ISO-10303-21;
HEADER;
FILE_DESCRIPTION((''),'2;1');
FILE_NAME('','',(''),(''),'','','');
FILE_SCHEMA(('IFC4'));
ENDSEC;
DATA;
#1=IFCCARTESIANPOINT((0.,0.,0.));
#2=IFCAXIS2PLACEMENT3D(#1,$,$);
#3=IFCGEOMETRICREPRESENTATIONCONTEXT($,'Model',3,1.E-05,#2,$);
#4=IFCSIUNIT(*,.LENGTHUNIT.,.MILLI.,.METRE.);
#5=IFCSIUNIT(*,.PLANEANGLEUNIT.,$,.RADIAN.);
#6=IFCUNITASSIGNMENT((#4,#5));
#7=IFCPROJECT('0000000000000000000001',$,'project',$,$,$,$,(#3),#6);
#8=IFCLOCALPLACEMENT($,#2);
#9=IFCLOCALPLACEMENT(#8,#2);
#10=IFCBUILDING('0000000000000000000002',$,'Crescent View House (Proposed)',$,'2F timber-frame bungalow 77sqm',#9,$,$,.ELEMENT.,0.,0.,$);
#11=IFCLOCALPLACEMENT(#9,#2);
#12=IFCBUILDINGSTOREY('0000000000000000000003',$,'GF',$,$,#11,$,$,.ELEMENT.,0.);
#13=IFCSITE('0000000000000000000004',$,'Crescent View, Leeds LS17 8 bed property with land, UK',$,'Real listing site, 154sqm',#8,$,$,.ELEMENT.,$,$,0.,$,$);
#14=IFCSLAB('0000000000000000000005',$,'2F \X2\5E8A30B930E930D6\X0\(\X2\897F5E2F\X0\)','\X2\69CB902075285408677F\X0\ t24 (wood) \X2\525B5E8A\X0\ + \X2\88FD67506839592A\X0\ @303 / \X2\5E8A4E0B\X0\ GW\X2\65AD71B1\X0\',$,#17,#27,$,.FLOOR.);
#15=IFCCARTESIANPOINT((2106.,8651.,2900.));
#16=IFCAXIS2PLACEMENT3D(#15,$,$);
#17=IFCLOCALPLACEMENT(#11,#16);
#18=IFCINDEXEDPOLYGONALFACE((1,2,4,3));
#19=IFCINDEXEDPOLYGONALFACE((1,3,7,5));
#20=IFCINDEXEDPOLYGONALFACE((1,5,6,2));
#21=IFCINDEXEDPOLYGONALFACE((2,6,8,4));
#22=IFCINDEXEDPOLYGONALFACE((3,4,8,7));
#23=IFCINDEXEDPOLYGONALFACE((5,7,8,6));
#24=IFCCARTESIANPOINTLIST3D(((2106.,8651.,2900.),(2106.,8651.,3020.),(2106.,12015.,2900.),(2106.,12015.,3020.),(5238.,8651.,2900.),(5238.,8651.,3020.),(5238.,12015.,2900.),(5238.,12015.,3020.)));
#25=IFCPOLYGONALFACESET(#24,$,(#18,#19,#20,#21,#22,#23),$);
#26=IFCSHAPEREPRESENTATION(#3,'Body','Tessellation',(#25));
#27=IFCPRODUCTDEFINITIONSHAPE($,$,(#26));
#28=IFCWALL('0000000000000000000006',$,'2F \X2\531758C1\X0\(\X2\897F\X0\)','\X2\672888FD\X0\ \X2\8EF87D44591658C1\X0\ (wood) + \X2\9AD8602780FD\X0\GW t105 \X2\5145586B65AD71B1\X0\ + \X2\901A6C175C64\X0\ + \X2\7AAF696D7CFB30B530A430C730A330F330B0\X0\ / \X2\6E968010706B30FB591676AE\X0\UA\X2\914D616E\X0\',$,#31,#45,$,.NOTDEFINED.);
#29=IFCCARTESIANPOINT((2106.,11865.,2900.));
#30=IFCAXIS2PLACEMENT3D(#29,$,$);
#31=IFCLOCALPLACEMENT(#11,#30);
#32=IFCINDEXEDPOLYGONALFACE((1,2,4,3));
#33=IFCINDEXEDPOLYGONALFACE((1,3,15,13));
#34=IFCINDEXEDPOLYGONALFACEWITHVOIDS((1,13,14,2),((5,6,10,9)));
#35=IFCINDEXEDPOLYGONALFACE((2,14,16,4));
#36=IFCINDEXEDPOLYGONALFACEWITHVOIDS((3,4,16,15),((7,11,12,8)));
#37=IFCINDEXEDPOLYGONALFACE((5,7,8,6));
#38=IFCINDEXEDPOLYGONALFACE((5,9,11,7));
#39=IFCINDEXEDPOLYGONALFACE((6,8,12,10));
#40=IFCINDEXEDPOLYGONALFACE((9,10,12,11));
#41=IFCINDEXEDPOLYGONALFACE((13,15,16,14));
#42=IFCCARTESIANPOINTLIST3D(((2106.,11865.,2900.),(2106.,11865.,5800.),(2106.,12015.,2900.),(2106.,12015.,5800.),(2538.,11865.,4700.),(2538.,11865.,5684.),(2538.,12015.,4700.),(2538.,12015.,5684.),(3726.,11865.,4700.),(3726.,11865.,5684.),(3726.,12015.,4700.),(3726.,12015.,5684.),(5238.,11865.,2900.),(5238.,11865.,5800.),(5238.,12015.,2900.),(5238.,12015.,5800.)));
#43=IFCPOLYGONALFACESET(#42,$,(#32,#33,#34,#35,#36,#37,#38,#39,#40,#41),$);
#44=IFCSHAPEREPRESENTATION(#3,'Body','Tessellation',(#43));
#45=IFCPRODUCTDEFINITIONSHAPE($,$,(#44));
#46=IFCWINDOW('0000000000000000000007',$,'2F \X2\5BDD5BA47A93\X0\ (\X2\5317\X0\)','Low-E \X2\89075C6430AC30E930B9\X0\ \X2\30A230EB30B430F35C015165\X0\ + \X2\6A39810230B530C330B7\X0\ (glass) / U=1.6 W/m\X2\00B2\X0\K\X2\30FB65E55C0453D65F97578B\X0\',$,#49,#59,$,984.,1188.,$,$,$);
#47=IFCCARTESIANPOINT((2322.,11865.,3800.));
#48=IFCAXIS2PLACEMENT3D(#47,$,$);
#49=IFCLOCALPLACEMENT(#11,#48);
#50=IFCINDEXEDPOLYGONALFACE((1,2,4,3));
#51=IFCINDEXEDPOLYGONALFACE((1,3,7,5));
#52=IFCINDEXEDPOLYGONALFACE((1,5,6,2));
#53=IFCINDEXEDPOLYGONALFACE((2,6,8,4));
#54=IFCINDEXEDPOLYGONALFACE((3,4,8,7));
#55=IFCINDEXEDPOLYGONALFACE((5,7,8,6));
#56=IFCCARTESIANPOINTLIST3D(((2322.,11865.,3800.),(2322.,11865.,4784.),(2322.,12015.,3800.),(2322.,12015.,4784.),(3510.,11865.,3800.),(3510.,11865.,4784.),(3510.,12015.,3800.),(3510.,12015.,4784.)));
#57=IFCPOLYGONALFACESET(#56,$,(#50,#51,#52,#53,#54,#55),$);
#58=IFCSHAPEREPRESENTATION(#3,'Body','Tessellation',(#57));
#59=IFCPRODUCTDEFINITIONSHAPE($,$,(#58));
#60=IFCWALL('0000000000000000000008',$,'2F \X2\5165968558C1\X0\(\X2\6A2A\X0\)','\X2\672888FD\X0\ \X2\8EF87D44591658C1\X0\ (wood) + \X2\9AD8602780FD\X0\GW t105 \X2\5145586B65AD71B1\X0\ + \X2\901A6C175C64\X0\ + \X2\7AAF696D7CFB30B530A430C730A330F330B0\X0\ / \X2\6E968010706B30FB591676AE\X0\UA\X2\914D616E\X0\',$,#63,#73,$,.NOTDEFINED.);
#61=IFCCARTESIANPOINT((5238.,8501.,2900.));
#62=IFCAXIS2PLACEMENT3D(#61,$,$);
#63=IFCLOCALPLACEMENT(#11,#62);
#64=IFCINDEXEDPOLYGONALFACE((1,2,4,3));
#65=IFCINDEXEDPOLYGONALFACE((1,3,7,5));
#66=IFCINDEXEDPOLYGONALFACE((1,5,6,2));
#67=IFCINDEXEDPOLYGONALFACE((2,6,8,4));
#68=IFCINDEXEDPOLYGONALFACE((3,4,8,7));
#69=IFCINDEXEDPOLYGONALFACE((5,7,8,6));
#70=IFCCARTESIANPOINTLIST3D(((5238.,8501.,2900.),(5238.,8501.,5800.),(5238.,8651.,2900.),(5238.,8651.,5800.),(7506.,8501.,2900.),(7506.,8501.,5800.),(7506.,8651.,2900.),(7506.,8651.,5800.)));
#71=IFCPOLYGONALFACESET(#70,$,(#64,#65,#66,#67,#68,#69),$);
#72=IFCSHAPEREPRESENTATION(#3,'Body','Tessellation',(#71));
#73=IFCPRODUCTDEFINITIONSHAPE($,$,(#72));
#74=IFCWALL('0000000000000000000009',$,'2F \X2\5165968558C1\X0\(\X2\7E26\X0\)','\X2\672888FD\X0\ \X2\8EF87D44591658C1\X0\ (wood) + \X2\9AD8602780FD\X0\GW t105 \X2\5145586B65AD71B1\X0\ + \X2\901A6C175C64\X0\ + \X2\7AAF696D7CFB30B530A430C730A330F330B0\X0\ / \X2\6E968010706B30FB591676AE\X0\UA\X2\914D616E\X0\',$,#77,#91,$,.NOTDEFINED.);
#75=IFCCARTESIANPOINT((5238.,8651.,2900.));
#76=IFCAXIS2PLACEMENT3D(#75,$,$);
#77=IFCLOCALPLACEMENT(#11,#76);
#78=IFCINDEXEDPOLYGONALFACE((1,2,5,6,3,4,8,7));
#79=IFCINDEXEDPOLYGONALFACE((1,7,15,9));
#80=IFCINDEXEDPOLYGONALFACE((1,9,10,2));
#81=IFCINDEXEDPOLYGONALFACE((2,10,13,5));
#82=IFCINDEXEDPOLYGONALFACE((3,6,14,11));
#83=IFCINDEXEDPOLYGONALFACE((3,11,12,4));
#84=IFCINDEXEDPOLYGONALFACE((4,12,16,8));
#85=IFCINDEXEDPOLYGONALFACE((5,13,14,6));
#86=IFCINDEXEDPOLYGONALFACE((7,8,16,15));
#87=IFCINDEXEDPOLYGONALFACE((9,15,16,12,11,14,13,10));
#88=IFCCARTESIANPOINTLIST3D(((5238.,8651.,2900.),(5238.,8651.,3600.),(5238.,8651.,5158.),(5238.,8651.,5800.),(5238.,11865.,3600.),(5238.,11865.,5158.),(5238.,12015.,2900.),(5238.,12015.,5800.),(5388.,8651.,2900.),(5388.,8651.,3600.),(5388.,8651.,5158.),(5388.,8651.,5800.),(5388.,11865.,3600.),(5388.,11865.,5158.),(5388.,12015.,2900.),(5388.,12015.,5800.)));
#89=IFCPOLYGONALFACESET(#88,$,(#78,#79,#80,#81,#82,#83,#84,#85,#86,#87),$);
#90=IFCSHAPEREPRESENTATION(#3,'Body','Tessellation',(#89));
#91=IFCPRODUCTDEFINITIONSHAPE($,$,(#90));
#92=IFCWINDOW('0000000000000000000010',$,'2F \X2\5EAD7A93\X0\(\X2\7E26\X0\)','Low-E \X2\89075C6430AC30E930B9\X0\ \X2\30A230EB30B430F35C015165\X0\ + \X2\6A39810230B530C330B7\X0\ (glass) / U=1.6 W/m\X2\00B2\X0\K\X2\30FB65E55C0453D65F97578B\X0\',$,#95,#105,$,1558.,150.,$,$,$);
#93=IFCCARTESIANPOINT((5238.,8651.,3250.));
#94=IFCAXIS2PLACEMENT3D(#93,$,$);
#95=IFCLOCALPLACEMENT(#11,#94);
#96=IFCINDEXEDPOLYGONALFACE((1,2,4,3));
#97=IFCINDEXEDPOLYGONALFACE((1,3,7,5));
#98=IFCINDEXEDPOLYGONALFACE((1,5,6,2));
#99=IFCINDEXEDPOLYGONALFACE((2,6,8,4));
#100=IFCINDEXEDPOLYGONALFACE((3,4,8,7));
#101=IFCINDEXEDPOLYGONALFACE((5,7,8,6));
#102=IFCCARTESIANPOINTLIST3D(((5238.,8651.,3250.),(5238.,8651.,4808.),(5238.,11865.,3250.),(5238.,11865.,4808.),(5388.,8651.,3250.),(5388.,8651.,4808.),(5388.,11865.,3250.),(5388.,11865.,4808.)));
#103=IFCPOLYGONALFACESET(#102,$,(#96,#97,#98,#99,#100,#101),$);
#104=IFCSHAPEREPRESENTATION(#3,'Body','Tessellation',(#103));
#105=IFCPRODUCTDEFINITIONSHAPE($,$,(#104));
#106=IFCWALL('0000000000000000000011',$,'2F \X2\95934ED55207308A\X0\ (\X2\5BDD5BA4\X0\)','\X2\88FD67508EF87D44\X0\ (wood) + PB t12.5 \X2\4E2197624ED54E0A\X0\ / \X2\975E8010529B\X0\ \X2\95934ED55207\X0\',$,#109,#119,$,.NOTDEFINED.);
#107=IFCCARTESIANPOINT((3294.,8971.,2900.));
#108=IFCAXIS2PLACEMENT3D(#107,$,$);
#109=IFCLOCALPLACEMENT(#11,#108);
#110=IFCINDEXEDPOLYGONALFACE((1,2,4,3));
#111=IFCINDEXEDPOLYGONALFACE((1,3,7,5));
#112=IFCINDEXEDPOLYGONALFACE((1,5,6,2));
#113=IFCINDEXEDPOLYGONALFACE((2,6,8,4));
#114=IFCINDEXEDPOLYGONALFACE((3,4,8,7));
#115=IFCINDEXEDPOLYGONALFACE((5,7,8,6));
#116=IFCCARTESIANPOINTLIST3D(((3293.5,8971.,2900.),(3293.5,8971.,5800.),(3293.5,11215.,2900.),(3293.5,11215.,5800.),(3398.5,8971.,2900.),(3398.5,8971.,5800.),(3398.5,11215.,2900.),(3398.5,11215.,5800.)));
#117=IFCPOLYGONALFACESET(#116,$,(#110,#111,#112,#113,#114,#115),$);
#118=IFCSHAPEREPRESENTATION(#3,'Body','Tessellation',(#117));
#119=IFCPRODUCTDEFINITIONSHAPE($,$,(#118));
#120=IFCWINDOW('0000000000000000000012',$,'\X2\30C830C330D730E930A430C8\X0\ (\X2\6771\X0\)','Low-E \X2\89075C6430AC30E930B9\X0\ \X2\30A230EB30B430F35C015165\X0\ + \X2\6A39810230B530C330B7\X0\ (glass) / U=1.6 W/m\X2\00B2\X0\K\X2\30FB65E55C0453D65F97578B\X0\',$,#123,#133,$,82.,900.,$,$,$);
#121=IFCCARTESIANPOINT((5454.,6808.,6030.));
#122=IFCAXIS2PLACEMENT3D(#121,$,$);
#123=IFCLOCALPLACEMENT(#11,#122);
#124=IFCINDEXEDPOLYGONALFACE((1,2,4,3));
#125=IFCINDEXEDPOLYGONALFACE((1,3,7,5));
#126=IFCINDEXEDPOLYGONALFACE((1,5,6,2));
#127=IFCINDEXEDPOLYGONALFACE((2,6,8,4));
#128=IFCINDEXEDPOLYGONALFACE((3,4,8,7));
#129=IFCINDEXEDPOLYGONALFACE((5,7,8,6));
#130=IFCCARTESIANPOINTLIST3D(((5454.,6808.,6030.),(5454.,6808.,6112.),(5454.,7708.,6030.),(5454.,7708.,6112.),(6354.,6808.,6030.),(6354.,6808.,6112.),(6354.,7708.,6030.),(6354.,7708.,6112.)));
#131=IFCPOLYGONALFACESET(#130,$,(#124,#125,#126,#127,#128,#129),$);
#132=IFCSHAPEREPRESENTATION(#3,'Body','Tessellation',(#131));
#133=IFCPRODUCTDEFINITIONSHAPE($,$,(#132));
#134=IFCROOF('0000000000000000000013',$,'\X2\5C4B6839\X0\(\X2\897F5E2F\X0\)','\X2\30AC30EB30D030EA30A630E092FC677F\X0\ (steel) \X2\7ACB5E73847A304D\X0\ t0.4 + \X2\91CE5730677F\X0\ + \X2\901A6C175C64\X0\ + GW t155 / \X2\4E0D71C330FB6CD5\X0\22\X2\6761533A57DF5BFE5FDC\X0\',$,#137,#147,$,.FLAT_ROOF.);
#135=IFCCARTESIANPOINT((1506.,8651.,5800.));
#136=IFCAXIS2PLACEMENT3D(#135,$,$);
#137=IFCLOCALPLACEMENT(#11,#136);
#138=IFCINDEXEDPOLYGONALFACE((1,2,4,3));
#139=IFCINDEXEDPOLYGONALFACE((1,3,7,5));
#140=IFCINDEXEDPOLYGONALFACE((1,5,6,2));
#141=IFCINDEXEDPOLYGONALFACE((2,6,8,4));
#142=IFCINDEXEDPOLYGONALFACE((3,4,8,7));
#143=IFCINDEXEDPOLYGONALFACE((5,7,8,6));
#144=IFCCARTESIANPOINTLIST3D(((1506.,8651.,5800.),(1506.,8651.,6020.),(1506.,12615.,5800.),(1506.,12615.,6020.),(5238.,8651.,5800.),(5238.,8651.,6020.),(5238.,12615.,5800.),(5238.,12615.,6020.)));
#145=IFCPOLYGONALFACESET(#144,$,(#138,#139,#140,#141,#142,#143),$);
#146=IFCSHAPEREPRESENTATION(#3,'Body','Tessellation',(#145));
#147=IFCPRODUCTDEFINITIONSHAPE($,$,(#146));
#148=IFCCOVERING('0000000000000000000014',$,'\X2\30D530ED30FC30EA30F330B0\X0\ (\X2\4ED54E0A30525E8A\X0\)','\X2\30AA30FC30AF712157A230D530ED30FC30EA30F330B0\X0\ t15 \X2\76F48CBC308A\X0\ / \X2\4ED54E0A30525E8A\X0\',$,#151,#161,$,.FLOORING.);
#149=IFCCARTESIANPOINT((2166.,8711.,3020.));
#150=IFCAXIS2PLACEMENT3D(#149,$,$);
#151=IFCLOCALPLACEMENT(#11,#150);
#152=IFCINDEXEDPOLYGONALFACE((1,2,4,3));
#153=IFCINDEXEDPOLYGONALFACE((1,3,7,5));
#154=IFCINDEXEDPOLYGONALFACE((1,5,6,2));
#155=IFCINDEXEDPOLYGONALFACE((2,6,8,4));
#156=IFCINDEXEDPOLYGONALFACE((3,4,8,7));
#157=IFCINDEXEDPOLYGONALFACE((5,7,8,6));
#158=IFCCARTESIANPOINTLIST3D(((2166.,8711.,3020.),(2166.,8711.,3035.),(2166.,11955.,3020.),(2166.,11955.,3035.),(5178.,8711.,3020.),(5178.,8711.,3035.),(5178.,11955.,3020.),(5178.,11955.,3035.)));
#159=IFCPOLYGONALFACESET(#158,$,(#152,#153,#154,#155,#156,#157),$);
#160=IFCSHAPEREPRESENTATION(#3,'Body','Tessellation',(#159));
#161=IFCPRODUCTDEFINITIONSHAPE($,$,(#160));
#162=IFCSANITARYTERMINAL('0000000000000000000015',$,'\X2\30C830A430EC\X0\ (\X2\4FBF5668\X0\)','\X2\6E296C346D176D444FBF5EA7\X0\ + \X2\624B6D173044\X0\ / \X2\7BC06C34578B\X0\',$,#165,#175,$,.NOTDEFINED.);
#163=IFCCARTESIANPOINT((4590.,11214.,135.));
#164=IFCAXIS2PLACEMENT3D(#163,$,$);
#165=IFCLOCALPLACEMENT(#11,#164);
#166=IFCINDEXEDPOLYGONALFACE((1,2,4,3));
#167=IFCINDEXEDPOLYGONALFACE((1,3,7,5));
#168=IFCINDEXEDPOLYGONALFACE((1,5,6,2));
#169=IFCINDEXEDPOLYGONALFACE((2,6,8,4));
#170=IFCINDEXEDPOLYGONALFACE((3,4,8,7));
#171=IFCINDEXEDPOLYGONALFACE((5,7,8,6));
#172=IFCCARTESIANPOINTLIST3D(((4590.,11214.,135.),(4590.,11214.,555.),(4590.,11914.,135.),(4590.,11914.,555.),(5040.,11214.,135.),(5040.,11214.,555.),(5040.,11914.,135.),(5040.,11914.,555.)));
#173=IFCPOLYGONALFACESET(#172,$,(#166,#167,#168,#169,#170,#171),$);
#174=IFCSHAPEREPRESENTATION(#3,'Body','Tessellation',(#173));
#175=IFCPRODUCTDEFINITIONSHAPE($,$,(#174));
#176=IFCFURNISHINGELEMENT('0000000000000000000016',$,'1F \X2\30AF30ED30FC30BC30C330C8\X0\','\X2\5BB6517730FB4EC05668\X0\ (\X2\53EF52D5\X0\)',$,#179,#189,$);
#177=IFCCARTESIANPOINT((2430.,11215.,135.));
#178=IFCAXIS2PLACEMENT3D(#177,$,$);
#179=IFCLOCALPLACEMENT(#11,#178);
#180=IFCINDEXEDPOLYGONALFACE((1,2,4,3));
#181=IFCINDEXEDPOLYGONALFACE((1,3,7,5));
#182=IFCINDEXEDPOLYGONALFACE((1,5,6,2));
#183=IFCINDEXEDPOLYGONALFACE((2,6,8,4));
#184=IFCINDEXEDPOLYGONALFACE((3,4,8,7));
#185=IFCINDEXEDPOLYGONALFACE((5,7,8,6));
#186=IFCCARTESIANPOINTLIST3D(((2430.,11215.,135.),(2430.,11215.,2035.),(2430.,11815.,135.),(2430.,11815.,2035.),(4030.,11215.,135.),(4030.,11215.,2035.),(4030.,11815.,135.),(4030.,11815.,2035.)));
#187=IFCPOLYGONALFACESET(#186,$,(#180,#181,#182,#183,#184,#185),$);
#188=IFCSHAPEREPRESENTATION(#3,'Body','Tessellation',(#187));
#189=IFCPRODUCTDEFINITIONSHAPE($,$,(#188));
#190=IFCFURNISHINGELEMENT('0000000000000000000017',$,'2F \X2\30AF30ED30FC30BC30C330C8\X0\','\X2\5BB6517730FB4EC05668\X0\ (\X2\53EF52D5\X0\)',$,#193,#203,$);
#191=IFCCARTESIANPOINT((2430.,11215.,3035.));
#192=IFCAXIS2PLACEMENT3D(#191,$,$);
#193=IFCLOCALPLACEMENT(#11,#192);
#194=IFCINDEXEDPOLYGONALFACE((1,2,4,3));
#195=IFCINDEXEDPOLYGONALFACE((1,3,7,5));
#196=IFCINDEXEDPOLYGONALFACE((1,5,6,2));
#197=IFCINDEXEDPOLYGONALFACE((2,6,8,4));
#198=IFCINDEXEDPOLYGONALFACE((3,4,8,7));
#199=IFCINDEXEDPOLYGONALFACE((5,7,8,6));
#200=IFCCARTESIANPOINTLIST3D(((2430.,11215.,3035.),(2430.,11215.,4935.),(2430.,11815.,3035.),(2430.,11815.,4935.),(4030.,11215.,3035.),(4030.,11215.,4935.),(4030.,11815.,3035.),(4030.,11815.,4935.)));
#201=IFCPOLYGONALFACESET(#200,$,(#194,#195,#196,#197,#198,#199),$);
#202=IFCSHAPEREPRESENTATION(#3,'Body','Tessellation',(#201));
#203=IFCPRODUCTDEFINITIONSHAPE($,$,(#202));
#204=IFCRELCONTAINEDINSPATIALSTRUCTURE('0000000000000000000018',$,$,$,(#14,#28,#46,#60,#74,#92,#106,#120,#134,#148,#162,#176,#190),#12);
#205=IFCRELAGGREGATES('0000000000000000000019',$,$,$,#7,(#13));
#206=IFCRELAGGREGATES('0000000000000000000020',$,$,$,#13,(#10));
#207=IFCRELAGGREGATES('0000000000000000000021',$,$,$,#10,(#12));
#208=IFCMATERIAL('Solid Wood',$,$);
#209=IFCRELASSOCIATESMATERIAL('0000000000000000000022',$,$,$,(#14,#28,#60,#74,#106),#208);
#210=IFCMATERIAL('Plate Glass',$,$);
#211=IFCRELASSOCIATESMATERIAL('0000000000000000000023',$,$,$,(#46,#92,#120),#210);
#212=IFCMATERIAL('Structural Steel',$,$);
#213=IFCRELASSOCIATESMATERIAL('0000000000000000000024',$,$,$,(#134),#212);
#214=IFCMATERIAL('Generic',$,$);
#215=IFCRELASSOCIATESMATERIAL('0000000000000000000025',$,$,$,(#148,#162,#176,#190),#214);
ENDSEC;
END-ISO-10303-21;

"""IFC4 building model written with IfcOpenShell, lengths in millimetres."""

from ifc_helpers import new_model, si_unit, frame, frame_2d, origin, place, context, project, spatial, rectangle, extrude, material, element, fill, save


model = new_model("IFC4")

# Units and contexts
model_context = context("Model", 3, precision=1e-05, world=origin())
ifc_project = project(units=[si_unit("LENGTHUNIT", "METRE", prefix="MILLI"), si_unit("PLANEANGLEUNIT", "RADIAN")], contexts=[model_context])

# Site, building, storey
site_placement = place(None, origin())
site = spatial("IfcSite", under=ifc_project, at=site_placement, Name="Crescent View, Leeds LS17 8 bed property with land, UK", ObjectType="Real listing site, 154sqm", CompositionType="ELEMENT", RefElevation=0.0)
building_placement = place(site_placement, origin())
building = spatial("IfcBuilding", under=site, at=building_placement, Name="Crescent View House (Proposed)", ObjectType="2F timber-frame bungalow 77sqm", CompositionType="ELEMENT", ElevationOfRefHeight=0.0, ElevationOfTerrain=0.0)
storey_placement = place(building_placement, origin())
storey = spatial("IfcBuildingStorey", under=building, at=storey_placement, Name="GF", CompositionType="ELEMENT", Elevation=0.0)

# Slab
ifc_material_1 = material(Name="Solid Wood")
slab_placement = place(storey_placement, frame((2106.0, 8651.0, 2900.0)))
element("IfcSlab", 1, at=slab_placement, inside=storey, material=ifc_material_1, Name="2F 床スラブ(西帯)", Description="構造用合板 t24 (wood) 剛床 + 製材根太 @303 / 床下 GW断熱", PredefinedType="FLOOR", context=model_context, shape_type="SweptSolid", body=[
    extrude(rectangle(XDim=3132.0, YDim=3364.0, at=frame_2d((1566.0, 1682.0))), frame((2106.0, 8651.0, 2900.0)), (0.0, 0.0, 1.0), 120.0),
])

# Wall, opening, window
wall_1_placement = place(storey_placement, frame((2106.0, 11865.0, 2900.0)))
wall_1 = element("IfcWall", 2, at=wall_1_placement, inside=storey, material=ifc_material_1, Name="2F 北壁(西)", Description="木製 軸組外壁 (wood) + 高性能GW t105 充填断熱 + 通気層 + 窯業系サイディング / 準耐火・外皮UA配慮", PredefinedType="NOTDEFINED", context=model_context, shape_type="SweptSolid", body=[
    extrude(rectangle(XDim=3132.0, YDim=150.0, at=frame_2d((1566.0, 75.0))), frame((2106.0, 11865.0, 2900.0)), (0.0, 0.0, 1.0), 2900.0),
])
opening_1_placement = place(storey_placement, frame((2322.0, 11865.0, 3800.0)))
opening_1 = element("IfcOpeningElement", 3, at=opening_1_placement, cuts=wall_1, PredefinedType="NOTDEFINED", context=model_context, shape_type="SweptSolid", body=[
    extrude(rectangle(XDim=1188.0, YDim=150.0, at=frame_2d((594.0, 75.0))), frame((2322.0, 11865.0, 3800.0)), (0.0, 0.0, 1.0), 984.0),
])
ifc_material_2 = material(Name="Plate Glass")
window_1_placement = place(storey_placement, frame((2322.0, 11865.0, 3800.0)))
window_1 = element("IfcWindow", 4, at=window_1_placement, inside=storey, material=ifc_material_2, Name="2F 寝室窓 (北)", Description="Low-E 複層ガラス アルゴン封入 + 樹脂サッシ (glass) / U=1.6 W/m²K・日射取得型", OverallHeight=984.0, OverallWidth=1188.0, context=model_context, shape_type="SweptSolid", body=[
    extrude(rectangle(XDim=1188.0, YDim=150.0, at=frame_2d((594.0, 75.0))), frame((2322.0, 11865.0, 3800.0)), (0.0, 0.0, 1.0), 984.0),
])
fill(opening_1, window_1)

# Wall
wall_2_placement = place(storey_placement, frame((5238.0, 8501.0, 2900.0)))
element("IfcWall", 5, at=wall_2_placement, inside=storey, material=ifc_material_1, Name="2F 入隅壁(横)", Description="木製 軸組外壁 (wood) + 高性能GW t105 充填断熱 + 通気層 + 窯業系サイディング / 準耐火・外皮UA配慮", PredefinedType="NOTDEFINED", context=model_context, shape_type="SweptSolid", body=[
    extrude(rectangle(XDim=2268.0, YDim=150.0, at=frame_2d((1134.0, 75.0))), frame((5238.0, 8501.0, 2900.0)), (0.0, 0.0, 1.0), 2900.0),
])

# Wall, opening, window
wall_3_placement = place(storey_placement, frame((5238.0, 8651.0, 2900.0)))
wall_3 = element("IfcWall", 6, at=wall_3_placement, inside=storey, material=ifc_material_1, Name="2F 入隅壁(縦)", Description="木製 軸組外壁 (wood) + 高性能GW t105 充填断熱 + 通気層 + 窯業系サイディング / 準耐火・外皮UA配慮", PredefinedType="NOTDEFINED", context=model_context, shape_type="SweptSolid", body=[
    extrude(rectangle(XDim=150.0, YDim=3364.0, at=frame_2d((75.0, 1682.0))), frame((5238.0, 8651.0, 2900.0)), (0.0, 0.0, 1.0), 2900.0),
])
opening_2_placement = place(storey_placement, frame((5238.0, 8651.0, 3250.0)))
opening_2 = element("IfcOpeningElement", 7, at=opening_2_placement, cuts=wall_3, PredefinedType="NOTDEFINED", context=model_context, shape_type="SweptSolid", body=[
    extrude(rectangle(XDim=150.0, YDim=3214.0, at=frame_2d((75.0, 1607.0))), frame((5238.0, 8651.0, 3250.0)), (0.0, 0.0, 1.0), 1558.0),
])
window_2_placement = place(storey_placement, frame((5238.0, 8651.0, 3250.0)))
window_2 = element("IfcWindow", 8, at=window_2_placement, inside=storey, material=ifc_material_2, Name="2F 庭窓(縦)", Description="Low-E 複層ガラス アルゴン封入 + 樹脂サッシ (glass) / U=1.6 W/m²K・日射取得型", OverallHeight=1558.0, OverallWidth=150.0, context=model_context, shape_type="SweptSolid", body=[
    extrude(rectangle(XDim=150.0, YDim=3214.0, at=frame_2d((75.0, 1607.0))), frame((5238.0, 8651.0, 3250.0)), (0.0, 0.0, 1.0), 1558.0),
])
fill(opening_2, window_2)

# Wall
wall_4_placement = place(storey_placement, frame((3294.0, 8971.0, 2900.0)))
element("IfcWall", 9, at=wall_4_placement, inside=storey, material=ifc_material_1, Name="2F 間仕切り (寝室)", Description="製材軸組 (wood) + PB t12.5 両面仕上 / 非耐力 間仕切", PredefinedType="NOTDEFINED", context=model_context, shape_type="SweptSolid", body=[
    extrude(rectangle(XDim=105.0, YDim=2244.0, at=frame_2d((52.0, 1122.0))), frame((3294.0, 8971.0, 2900.0)), (0.0, 0.0, 1.0), 2900.0),
])

# Window
window_3_placement = place(storey_placement, frame((5454.0, 6808.0, 6030.0)))
element("IfcWindow", 10, at=window_3_placement, inside=storey, material=ifc_material_2, Name="トップライト (東)", Description="Low-E 複層ガラス アルゴン封入 + 樹脂サッシ (glass) / U=1.6 W/m²K・日射取得型", OverallHeight=82.0, OverallWidth=900.0, context=model_context, shape_type="SweptSolid", body=[
    extrude(rectangle(XDim=900.0, YDim=900.0, at=frame_2d((450.0, 450.0))), frame((5454.0, 6808.0, 6030.0)), (0.0, 0.0, 1.0), 82.0),
])

# Roof
ifc_material_3 = material(Name="Structural Steel")
for number, where, name in (
    (11, (1506.0, 8651.0, 5800.0), "屋根(西帯)"),
):
    element("IfcRoof", number, at=place(storey_placement, frame(where)), inside=storey, material=ifc_material_3, Name=name, Description="ガルバリウム鋼板 (steel) 立平葺き t0.4 + 野地板 + 通気層 + GW t155 / 不燃・法22条区域対応", PredefinedType="FLAT_ROOF", context=model_context, shape_type="SweptSolid", body=[
        extrude(rectangle(XDim=3732.0, YDim=3964.0, at=frame_2d((1866.0, 1982.0))), frame((1506.0, 8651.0, 5800.0)), (0.0, 0.0, 1.0), 220.0),
    ])

# Covering
ifc_material_4 = material(Name="Generic")
covering_placement = place(storey_placement, frame((2166.0, 8711.0, 3020.0)))
element("IfcCovering", 12, at=covering_placement, inside=storey, material=ifc_material_4, Name="フローリング (仕上げ床)", Description="オーク無垢フローリング t15 直貼り / 仕上げ床", PredefinedType="FLOORING", context=model_context, shape_type="SweptSolid", body=[
    extrude(rectangle(XDim=3012.0, YDim=3244.0, at=frame_2d((1506.0, 1622.0))), frame((2166.0, 8711.0, 3020.0)), (0.0, 0.0, 1.0), 15.0),
])

# Sanitary terminal
sanitary_terminal_placement = place(storey_placement, frame((4590.0, 11214.0, 135.0)))
element("IfcSanitaryTerminal", 13, at=sanitary_terminal_placement, inside=storey, material=ifc_material_4, Name="トイレ (便器)", Description="温水洗浄便座 + 手洗い / 節水型", PredefinedType="NOTDEFINED", context=model_context, shape_type="SweptSolid", body=[
    extrude(rectangle(XDim=450.0, YDim=700.0, at=frame_2d((225.0, 350.0))), frame((4590.0, 11214.0, 135.0)), (0.0, 0.0, 1.0), 420.0),
])

# Furnishing elements
furnishing_1_placement = place(storey_placement, frame((2430.0, 11215.0, 135.0)))
element("IfcFurnishingElement", 14, at=furnishing_1_placement, inside=storey, material=ifc_material_4, Name="1F クローゼット", Description="家具・什器 (可動)", context=model_context, shape_type="SweptSolid", body=[
    extrude(rectangle(XDim=1600.0, YDim=600.0, at=frame_2d((800.0, 300.0))), frame((2430.0, 11215.0, 135.0)), (0.0, 0.0, 1.0), 1900.0),
])
furnishing_2_placement = place(storey_placement, frame((2430.0, 11215.0, 3035.0)))
element("IfcFurnishingElement", 15, at=furnishing_2_placement, inside=storey, material=ifc_material_4, Name="2F クローゼット", Description="家具・什器 (可動)", context=model_context, shape_type="SweptSolid", body=[
    extrude(rectangle(XDim=1600.0, YDim=600.0, at=frame_2d((800.0, 300.0))), frame((2430.0, 11215.0, 3035.0)), (0.0, 0.0, 1.0), 1900.0),
])

save(model, "model.ifc")
